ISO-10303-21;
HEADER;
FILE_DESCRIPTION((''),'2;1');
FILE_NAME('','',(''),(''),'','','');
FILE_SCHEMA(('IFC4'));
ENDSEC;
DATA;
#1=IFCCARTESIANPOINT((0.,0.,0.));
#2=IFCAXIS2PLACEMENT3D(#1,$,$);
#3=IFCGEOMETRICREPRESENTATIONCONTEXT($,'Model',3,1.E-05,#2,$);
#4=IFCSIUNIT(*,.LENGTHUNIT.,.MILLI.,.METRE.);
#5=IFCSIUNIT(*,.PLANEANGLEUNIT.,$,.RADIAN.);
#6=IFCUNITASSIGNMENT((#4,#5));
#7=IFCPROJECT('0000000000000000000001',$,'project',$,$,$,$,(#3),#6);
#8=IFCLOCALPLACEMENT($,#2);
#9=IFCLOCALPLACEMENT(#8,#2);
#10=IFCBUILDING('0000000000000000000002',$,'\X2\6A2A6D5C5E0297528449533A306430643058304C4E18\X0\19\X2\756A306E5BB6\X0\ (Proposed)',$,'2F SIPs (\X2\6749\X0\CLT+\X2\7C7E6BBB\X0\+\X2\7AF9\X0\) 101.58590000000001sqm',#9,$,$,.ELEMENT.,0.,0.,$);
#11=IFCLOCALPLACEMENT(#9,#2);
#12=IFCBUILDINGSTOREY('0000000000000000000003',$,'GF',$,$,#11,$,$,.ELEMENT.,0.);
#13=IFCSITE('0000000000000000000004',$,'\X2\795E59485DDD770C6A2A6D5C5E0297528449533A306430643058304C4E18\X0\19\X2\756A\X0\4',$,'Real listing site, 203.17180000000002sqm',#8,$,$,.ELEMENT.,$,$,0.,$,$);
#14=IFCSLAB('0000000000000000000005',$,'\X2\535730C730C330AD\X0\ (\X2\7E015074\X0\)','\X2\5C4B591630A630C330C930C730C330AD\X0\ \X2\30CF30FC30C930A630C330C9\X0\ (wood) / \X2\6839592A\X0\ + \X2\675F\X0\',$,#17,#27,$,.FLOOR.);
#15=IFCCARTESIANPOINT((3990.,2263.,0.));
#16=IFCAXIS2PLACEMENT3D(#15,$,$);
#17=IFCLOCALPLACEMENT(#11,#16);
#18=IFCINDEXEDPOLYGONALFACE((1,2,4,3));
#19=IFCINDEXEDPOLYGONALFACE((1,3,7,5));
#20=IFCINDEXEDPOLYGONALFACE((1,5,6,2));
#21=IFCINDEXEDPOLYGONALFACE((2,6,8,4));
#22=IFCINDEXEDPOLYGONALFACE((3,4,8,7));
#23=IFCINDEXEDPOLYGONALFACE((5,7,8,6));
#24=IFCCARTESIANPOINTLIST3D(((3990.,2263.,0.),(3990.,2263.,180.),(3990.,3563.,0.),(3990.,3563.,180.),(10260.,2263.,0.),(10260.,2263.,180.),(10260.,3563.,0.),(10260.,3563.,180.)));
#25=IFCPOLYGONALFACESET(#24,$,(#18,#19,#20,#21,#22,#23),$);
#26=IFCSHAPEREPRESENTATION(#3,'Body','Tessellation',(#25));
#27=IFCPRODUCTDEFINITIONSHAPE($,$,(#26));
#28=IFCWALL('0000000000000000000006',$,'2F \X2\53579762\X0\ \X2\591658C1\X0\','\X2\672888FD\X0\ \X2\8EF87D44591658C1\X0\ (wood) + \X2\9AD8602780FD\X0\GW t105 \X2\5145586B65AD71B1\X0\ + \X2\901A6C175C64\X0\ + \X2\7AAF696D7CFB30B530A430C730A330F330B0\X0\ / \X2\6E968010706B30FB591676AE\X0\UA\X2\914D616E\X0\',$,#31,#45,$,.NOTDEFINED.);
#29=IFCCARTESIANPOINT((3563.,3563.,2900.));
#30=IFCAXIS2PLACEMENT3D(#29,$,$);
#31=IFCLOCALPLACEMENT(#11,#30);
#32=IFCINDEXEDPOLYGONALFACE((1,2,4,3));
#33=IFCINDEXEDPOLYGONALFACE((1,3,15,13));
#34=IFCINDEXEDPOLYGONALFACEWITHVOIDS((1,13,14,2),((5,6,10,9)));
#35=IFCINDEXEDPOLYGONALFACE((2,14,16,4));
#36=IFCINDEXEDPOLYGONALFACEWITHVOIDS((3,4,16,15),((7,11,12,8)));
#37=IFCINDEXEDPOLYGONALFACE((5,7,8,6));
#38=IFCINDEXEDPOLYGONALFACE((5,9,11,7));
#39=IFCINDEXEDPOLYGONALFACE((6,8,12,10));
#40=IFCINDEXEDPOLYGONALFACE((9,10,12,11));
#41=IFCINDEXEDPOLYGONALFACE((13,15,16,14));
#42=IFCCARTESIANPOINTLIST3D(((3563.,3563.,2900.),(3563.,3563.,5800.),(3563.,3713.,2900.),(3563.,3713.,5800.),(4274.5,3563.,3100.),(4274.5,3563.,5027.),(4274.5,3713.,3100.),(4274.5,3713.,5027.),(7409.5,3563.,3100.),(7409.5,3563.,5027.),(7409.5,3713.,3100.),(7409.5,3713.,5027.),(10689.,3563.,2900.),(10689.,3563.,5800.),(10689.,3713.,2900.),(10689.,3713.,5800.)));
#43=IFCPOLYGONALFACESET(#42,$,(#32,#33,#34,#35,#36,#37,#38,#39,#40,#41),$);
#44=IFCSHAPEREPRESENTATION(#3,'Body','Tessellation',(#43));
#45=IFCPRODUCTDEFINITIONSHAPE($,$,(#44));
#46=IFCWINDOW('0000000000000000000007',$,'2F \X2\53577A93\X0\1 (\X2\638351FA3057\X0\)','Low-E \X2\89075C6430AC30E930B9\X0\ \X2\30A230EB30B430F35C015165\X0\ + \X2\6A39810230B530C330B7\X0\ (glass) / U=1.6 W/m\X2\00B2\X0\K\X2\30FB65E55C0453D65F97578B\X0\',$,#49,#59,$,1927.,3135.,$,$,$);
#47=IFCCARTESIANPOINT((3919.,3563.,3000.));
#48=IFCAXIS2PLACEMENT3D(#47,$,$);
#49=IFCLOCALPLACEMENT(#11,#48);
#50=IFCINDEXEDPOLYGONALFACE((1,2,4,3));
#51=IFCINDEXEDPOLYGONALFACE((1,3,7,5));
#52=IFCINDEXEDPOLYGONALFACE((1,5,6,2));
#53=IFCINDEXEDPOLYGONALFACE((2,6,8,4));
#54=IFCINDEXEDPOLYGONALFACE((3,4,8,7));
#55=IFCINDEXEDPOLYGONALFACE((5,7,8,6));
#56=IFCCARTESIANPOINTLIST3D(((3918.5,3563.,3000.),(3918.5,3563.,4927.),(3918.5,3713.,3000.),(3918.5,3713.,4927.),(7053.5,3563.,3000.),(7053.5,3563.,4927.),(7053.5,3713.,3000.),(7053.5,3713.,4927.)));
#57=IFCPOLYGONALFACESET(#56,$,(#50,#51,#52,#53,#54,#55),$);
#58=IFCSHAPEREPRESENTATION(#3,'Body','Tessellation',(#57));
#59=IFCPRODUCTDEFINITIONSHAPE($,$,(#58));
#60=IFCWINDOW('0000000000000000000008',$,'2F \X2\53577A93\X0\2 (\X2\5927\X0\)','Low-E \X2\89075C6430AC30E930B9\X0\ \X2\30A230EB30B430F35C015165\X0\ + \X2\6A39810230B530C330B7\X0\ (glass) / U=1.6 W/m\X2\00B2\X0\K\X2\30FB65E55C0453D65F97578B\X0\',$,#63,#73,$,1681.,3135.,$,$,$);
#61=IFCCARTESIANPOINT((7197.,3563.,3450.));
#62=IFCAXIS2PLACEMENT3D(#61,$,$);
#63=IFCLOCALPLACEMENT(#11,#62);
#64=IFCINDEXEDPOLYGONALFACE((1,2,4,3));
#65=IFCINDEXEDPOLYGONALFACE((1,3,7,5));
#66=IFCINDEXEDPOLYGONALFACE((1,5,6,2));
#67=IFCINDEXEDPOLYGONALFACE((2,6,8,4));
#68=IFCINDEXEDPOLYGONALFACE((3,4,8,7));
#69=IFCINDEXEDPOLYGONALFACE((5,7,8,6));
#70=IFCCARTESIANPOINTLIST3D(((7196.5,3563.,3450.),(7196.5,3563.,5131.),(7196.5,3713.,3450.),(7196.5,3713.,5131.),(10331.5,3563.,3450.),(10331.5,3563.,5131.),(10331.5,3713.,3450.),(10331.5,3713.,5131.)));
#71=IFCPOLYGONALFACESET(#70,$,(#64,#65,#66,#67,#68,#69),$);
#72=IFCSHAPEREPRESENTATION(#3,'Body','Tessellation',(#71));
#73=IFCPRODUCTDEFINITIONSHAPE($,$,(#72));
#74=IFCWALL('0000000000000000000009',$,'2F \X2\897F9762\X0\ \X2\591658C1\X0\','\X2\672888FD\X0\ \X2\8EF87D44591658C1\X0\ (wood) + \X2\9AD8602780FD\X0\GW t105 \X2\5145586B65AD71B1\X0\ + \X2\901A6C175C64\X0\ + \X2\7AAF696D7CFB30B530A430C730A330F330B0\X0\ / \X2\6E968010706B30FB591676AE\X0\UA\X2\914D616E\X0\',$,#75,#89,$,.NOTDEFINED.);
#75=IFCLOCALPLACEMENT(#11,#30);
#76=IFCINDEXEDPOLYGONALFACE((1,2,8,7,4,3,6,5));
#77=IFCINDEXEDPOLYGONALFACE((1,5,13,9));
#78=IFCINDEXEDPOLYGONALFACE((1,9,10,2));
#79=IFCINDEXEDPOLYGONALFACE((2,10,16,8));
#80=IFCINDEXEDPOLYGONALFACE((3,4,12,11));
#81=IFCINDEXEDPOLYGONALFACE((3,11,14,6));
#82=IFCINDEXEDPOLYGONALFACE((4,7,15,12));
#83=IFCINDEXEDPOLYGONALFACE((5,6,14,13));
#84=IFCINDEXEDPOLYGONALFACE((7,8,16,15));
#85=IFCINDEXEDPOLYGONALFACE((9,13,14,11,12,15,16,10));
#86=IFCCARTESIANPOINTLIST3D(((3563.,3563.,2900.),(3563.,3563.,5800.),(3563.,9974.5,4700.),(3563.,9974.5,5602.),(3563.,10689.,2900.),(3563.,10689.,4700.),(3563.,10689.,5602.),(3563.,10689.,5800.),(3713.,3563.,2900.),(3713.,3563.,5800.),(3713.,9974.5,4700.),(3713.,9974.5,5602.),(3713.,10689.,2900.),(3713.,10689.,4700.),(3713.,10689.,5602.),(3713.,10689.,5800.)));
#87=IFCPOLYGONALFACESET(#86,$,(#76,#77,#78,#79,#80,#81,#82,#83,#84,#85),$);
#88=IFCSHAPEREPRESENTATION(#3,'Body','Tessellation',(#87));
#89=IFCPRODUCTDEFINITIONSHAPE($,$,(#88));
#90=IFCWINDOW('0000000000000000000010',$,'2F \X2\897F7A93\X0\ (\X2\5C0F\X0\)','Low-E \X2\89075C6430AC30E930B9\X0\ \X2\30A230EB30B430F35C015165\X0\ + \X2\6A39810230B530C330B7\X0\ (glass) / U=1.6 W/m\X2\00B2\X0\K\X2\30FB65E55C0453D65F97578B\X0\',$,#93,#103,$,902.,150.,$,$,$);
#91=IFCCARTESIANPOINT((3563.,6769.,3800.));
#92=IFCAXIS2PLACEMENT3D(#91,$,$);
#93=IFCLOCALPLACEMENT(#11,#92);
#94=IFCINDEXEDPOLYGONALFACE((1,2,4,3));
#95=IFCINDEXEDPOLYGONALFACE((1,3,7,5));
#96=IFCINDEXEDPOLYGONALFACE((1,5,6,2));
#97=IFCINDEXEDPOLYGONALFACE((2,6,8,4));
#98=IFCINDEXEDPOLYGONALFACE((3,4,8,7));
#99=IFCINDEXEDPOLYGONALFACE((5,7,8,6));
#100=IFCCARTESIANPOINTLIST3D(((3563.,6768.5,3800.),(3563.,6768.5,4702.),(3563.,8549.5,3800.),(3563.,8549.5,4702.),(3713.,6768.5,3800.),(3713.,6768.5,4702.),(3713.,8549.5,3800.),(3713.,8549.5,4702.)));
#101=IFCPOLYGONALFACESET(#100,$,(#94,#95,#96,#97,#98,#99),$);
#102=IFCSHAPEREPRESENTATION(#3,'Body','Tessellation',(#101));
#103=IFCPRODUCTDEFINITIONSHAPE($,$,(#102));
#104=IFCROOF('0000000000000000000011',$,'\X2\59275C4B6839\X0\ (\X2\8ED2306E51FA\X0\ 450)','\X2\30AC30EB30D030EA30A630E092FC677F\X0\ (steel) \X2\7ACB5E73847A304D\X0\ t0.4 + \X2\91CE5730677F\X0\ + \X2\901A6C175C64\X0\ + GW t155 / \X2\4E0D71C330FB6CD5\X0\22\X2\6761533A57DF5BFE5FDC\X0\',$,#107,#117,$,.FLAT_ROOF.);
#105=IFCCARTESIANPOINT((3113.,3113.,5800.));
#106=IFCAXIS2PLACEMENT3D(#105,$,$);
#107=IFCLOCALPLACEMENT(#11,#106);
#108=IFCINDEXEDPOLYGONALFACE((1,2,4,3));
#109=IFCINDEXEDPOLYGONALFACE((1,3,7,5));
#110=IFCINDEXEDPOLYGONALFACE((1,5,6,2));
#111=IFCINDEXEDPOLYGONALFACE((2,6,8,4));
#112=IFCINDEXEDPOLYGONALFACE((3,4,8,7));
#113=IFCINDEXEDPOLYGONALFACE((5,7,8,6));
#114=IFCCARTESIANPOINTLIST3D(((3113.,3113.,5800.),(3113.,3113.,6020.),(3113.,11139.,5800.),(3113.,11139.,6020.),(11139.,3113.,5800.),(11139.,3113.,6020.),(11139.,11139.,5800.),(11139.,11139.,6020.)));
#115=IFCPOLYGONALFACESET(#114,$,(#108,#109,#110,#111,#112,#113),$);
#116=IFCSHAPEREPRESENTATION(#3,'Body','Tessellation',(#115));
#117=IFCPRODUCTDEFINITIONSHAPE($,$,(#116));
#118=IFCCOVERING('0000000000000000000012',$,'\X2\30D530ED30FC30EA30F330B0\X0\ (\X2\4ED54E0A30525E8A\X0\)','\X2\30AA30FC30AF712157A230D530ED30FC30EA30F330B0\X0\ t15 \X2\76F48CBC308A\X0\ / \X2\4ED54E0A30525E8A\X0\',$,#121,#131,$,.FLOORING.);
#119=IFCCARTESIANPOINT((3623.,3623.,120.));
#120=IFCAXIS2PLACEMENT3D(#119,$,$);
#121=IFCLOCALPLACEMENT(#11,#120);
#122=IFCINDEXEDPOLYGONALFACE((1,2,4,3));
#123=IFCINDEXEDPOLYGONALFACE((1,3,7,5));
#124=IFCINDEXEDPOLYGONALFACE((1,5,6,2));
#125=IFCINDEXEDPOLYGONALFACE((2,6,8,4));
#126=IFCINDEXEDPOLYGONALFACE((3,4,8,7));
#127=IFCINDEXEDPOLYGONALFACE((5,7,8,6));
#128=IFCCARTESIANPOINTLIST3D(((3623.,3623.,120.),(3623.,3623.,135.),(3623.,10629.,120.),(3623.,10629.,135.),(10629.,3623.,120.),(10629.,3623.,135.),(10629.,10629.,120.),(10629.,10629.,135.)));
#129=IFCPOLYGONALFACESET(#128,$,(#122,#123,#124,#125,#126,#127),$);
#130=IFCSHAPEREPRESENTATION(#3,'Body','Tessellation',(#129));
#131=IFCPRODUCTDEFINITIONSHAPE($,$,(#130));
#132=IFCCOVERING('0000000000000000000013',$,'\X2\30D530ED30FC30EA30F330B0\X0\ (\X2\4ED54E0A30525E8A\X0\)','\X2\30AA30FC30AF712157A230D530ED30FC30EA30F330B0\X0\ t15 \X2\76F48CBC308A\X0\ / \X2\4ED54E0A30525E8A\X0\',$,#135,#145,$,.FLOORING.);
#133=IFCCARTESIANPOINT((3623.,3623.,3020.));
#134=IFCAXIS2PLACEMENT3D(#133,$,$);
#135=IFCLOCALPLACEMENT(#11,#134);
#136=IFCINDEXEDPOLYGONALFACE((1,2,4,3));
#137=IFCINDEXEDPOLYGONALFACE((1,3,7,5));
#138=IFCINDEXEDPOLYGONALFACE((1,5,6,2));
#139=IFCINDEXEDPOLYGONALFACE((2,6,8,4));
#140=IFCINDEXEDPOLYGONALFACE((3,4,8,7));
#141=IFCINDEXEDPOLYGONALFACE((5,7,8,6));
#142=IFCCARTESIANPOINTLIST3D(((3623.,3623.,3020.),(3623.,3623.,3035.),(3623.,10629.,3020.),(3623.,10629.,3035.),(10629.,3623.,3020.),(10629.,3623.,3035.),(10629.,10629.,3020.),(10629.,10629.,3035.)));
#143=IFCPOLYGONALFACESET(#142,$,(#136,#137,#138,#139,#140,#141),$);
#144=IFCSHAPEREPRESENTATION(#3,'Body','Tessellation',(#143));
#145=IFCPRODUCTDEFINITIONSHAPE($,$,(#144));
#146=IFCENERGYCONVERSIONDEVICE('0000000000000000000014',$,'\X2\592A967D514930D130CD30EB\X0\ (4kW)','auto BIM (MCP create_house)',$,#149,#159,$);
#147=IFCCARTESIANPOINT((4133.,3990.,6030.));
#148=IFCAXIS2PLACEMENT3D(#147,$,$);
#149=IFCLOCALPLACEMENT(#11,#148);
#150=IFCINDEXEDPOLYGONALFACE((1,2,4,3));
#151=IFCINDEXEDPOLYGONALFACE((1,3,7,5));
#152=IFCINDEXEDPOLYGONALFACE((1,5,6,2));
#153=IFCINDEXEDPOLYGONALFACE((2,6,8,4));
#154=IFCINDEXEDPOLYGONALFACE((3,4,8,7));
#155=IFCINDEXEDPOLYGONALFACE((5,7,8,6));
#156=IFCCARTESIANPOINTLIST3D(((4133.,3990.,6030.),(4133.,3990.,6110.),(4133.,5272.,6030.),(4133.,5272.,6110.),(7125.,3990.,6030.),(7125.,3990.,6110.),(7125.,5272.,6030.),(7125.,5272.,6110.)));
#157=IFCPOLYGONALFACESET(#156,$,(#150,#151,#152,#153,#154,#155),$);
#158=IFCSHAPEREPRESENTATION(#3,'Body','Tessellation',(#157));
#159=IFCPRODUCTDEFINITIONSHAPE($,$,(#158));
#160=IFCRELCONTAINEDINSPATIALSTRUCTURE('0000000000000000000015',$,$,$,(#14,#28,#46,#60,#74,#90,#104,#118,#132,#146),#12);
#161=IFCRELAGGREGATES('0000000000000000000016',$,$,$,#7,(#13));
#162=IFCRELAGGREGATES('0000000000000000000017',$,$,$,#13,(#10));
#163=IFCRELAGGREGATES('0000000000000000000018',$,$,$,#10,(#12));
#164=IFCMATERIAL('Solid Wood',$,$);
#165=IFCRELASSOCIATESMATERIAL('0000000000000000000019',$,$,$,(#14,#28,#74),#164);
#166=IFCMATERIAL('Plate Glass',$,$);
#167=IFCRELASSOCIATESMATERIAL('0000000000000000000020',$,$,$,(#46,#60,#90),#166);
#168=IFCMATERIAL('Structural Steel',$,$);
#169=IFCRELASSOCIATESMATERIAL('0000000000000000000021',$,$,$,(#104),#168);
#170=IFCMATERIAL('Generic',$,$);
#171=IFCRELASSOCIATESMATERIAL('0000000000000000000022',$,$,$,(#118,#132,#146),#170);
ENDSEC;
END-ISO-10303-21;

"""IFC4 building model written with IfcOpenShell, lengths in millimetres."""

from ifc_helpers import new_model, si_unit, frame, frame_2d, origin, place, context, project, spatial, rectangle, extrude, material, element, fill, save


model = new_model("IFC4")

# Units and contexts
model_context = context("Model", 3, precision=1e-05, world=origin())
ifc_project = project(units=[si_unit("LENGTHUNIT", "METRE", prefix="MILLI"), si_unit("PLANEANGLEUNIT", "RADIAN")], contexts=[model_context])

# Site, building, storey
site_placement = place(None, origin())
site = spatial("IfcSite", under=ifc_project, at=site_placement, Name="神奈川県横浜市青葉区つつじが丘19番4", ObjectType="Real listing site, 203.17180000000002sqm", CompositionType="ELEMENT", RefElevation=0.0)
building_placement = place(site_placement, origin())
building = spatial("IfcBuilding", under=site, at=building_placement, Name="横浜市青葉区つつじが丘19番の家 (Proposed)", ObjectType="2F SIPs (杉CLT+籾殻+竹) 101.58590000000001sqm", CompositionType="ELEMENT", ElevationOfRefHeight=0.0, ElevationOfTerrain=0.0)
storey_placement = place(building_placement, origin())
storey = spatial("IfcBuildingStorey", under=building, at=storey_placement, Name="GF", CompositionType="ELEMENT", Elevation=0.0)

# Slab
ifc_material_1 = material(Name="Solid Wood")
slab_1_placement = place(storey_placement, frame((3990.0, 2263.0, 0.0)))
element("IfcSlab", 1, at=slab_1_placement, inside=storey, material=ifc_material_1, Name="南デッキ (縁側)", Description="屋外ウッドデッキ ハードウッド (wood) / 根太 + 束", PredefinedType="FLOOR", context=model_context, shape_type="SweptSolid", body=[
    extrude(rectangle(XDim=6270.0, YDim=1300.0, at=frame_2d((3135.0, 650.0))), frame((3990.0, 2263.0, 0.0)), (0.0, 0.0, 1.0), 180.0),
])

# Shared definitions
ifc_material_2 = material(Name="Plate Glass")

# Wall, openings, windows
wall_1_placement = place(storey_placement, frame((3563.0, 3563.0, 2900.0)))
wall_1 = element("IfcWall", 2, at=wall_1_placement, inside=storey, material=ifc_material_1, Name="2F 南面 外壁", Description="木製 軸組外壁 (wood) + 高性能GW t105 充填断熱 + 通気層 + 窯業系サイディング / 準耐火・外皮UA配慮", PredefinedType="NOTDEFINED", context=model_context, shape_type="SweptSolid", body=[
    extrude(rectangle(XDim=7126.0, YDim=150.0, at=frame_2d((3563.0, 75.0))), frame((3563.0, 3563.0, 2900.0)), (0.0, 0.0, 1.0), 2900.0),
])
opening_1_placement = place(storey_placement, frame((3919.0, 3563.0, 3000.0)))
opening_1 = element("IfcOpeningElement", 3, at=opening_1_placement, cuts=wall_1, PredefinedType="NOTDEFINED", context=model_context, shape_type="SweptSolid", body=[
    extrude(rectangle(XDim=3135.0, YDim=150.0, at=frame_2d((1567.0, 75.0))), frame((3919.0, 3563.0, 3000.0)), (0.0, 0.0, 1.0), 1927.0),
])
opening_2_placement = place(storey_placement, frame((7197.0, 3563.0, 3450.0)))
opening_2 = element("IfcOpeningElement", 4, at=opening_2_placement, cuts=wall_1, PredefinedType="NOTDEFINED", context=model_context, shape_type="SweptSolid", body=[
    extrude(rectangle(XDim=3135.0, YDim=150.0, at=frame_2d((1567.0, 75.0))), frame((7197.0, 3563.0, 3450.0)), (0.0, 0.0, 1.0), 1681.0),
])
window_1_placement = place(storey_placement, frame((3919.0, 3563.0, 3000.0)))
window_1 = element("IfcWindow", 5, at=window_1_placement, inside=storey, material=ifc_material_2, Name="2F 南窓1 (掃出し)", Description="Low-E 複層ガラス アルゴン封入 + 樹脂サッシ (glass) / U=1.6 W/m²K・日射取得型", OverallHeight=1927.0, OverallWidth=3135.0, context=model_context, shape_type="SweptSolid", body=[
    extrude(rectangle(XDim=3135.0, YDim=150.0, at=frame_2d((1567.0, 75.0))), frame((3919.0, 3563.0, 3000.0)), (0.0, 0.0, 1.0), 1927.0),
])
fill(opening_1, window_1)
window_2_placement = place(storey_placement, frame((7197.0, 3563.0, 3450.0)))
window_2 = element("IfcWindow", 6, at=window_2_placement, inside=storey, material=ifc_material_2, Name="2F 南窓2 (大)", Description="Low-E 複層ガラス アルゴン封入 + 樹脂サッシ (glass) / U=1.6 W/m²K・日射取得型", OverallHeight=1681.0, OverallWidth=3135.0, context=model_context, shape_type="SweptSolid", body=[
    extrude(rectangle(XDim=3135.0, YDim=150.0, at=frame_2d((1567.0, 75.0))), frame((7197.0, 3563.0, 3450.0)), (0.0, 0.0, 1.0), 1681.0),
])
fill(opening_2, window_2)

# Wall, opening, window
wall_2_placement = place(storey_placement, frame((3563.0, 3563.0, 2900.0)))
wall_2 = element("IfcWall", 7, at=wall_2_placement, inside=storey, material=ifc_material_1, Name="2F 西面 外壁", Description="木製 軸組外壁 (wood) + 高性能GW t105 充填断熱 + 通気層 + 窯業系サイディング / 準耐火・外皮UA配慮", PredefinedType="NOTDEFINED", context=model_context, shape_type="SweptSolid", body=[
    extrude(rectangle(XDim=150.0, YDim=7126.0, at=frame_2d((75.0, 3563.0))), frame((3563.0, 3563.0, 2900.0)), (0.0, 0.0, 1.0), 2900.0),
])
opening_3_placement = place(storey_placement, frame((3563.0, 6769.0, 3800.0)))
opening_3 = element("IfcOpeningElement", 8, at=opening_3_placement, cuts=wall_2, PredefinedType="NOTDEFINED", context=model_context, shape_type="SweptSolid", body=[
    extrude(rectangle(XDim=150.0, YDim=1781.0, at=frame_2d((75.0, 890.0))), frame((3563.0, 6769.0, 3800.0)), (0.0, 0.0, 1.0), 902.0),
])
window_3_placement = place(storey_placement, frame((3563.0, 6769.0, 3800.0)))
window_3 = element("IfcWindow", 9, at=window_3_placement, inside=storey, material=ifc_material_2, Name="2F 西窓 (小)", Description="Low-E 複層ガラス アルゴン封入 + 樹脂サッシ (glass) / U=1.6 W/m²K・日射取得型", OverallHeight=902.0, OverallWidth=150.0, context=model_context, shape_type="SweptSolid", body=[
    extrude(rectangle(XDim=150.0, YDim=1781.0, at=frame_2d((75.0, 890.0))), frame((3563.0, 6769.0, 3800.0)), (0.0, 0.0, 1.0), 902.0),
])
fill(opening_3, window_3)

# Roof
ifc_material_3 = material(Name="Structural Steel")
roof_placement = place(storey_placement, frame((3113.0, 3113.0, 5800.0)))
element("IfcRoof", 10, at=roof_placement, inside=storey, material=ifc_material_3, Name="大屋根 (軒の出 450)", Description="ガルバリウム鋼板 (steel) 立平葺き t0.4 + 野地板 + 通気層 + GW t155 / 不燃・法22条区域対応", PredefinedType="FLAT_ROOF", context=model_context, shape_type="SweptSolid", body=[
    extrude(rectangle(XDim=8026.0, YDim=8026.0, at=frame_2d((4013.0, 4013.0))), frame((3113.0, 3113.0, 5800.0)), (0.0, 0.0, 1.0), 220.0),
])

# Coverings
ifc_material_4 = material(Name="Generic")
covering_1_placement = place(storey_placement, frame((3623.0, 3623.0, 120.0)))
element("IfcCovering", 11, at=covering_1_placement, inside=storey, material=ifc_material_4, Name="フローリング (仕上げ床)", Description="オーク無垢フローリング t15 直貼り / 仕上げ床", PredefinedType="FLOORING", context=model_context, shape_type="SweptSolid", body=[
    extrude(rectangle(XDim=7006.0, YDim=7006.0, at=frame_2d((3503.0, 3503.0))), frame((3623.0, 3623.0, 120.0)), (0.0, 0.0, 1.0), 15.0),
])
covering_2_placement = place(storey_placement, frame((3623.0, 3623.0, 3020.0)))
element("IfcCovering", 12, at=covering_2_placement, inside=storey, material=ifc_material_4, Name="フローリング (仕上げ床)", Description="オーク無垢フローリング t15 直貼り / 仕上げ床", PredefinedType="FLOORING", context=model_context, shape_type="SweptSolid", body=[
    extrude(rectangle(XDim=7006.0, YDim=7006.0, at=frame_2d((3503.0, 3503.0))), frame((3623.0, 3623.0, 3020.0)), (0.0, 0.0, 1.0), 15.0),
])

# Energy conversion device
energy_conversion_device_placement = place(storey_placement, frame((4133.0, 3990.0, 6030.0)))
element("IfcEnergyConversionDevice", 13, at=energy_conversion_device_placement, inside=storey, material=ifc_material_4, Name="太陽光パネル (4kW)", Description="auto BIM (MCP create_house)", context=model_context, shape_type="SweptSolid", body=[
    extrude(rectangle(XDim=2992.0, YDim=1282.0, at=frame_2d((1496.0, 641.0))), frame((4133.0, 3990.0, 6030.0)), (0.0, 0.0, 1.0), 80.0),
])

save(model, "model.ifc")
